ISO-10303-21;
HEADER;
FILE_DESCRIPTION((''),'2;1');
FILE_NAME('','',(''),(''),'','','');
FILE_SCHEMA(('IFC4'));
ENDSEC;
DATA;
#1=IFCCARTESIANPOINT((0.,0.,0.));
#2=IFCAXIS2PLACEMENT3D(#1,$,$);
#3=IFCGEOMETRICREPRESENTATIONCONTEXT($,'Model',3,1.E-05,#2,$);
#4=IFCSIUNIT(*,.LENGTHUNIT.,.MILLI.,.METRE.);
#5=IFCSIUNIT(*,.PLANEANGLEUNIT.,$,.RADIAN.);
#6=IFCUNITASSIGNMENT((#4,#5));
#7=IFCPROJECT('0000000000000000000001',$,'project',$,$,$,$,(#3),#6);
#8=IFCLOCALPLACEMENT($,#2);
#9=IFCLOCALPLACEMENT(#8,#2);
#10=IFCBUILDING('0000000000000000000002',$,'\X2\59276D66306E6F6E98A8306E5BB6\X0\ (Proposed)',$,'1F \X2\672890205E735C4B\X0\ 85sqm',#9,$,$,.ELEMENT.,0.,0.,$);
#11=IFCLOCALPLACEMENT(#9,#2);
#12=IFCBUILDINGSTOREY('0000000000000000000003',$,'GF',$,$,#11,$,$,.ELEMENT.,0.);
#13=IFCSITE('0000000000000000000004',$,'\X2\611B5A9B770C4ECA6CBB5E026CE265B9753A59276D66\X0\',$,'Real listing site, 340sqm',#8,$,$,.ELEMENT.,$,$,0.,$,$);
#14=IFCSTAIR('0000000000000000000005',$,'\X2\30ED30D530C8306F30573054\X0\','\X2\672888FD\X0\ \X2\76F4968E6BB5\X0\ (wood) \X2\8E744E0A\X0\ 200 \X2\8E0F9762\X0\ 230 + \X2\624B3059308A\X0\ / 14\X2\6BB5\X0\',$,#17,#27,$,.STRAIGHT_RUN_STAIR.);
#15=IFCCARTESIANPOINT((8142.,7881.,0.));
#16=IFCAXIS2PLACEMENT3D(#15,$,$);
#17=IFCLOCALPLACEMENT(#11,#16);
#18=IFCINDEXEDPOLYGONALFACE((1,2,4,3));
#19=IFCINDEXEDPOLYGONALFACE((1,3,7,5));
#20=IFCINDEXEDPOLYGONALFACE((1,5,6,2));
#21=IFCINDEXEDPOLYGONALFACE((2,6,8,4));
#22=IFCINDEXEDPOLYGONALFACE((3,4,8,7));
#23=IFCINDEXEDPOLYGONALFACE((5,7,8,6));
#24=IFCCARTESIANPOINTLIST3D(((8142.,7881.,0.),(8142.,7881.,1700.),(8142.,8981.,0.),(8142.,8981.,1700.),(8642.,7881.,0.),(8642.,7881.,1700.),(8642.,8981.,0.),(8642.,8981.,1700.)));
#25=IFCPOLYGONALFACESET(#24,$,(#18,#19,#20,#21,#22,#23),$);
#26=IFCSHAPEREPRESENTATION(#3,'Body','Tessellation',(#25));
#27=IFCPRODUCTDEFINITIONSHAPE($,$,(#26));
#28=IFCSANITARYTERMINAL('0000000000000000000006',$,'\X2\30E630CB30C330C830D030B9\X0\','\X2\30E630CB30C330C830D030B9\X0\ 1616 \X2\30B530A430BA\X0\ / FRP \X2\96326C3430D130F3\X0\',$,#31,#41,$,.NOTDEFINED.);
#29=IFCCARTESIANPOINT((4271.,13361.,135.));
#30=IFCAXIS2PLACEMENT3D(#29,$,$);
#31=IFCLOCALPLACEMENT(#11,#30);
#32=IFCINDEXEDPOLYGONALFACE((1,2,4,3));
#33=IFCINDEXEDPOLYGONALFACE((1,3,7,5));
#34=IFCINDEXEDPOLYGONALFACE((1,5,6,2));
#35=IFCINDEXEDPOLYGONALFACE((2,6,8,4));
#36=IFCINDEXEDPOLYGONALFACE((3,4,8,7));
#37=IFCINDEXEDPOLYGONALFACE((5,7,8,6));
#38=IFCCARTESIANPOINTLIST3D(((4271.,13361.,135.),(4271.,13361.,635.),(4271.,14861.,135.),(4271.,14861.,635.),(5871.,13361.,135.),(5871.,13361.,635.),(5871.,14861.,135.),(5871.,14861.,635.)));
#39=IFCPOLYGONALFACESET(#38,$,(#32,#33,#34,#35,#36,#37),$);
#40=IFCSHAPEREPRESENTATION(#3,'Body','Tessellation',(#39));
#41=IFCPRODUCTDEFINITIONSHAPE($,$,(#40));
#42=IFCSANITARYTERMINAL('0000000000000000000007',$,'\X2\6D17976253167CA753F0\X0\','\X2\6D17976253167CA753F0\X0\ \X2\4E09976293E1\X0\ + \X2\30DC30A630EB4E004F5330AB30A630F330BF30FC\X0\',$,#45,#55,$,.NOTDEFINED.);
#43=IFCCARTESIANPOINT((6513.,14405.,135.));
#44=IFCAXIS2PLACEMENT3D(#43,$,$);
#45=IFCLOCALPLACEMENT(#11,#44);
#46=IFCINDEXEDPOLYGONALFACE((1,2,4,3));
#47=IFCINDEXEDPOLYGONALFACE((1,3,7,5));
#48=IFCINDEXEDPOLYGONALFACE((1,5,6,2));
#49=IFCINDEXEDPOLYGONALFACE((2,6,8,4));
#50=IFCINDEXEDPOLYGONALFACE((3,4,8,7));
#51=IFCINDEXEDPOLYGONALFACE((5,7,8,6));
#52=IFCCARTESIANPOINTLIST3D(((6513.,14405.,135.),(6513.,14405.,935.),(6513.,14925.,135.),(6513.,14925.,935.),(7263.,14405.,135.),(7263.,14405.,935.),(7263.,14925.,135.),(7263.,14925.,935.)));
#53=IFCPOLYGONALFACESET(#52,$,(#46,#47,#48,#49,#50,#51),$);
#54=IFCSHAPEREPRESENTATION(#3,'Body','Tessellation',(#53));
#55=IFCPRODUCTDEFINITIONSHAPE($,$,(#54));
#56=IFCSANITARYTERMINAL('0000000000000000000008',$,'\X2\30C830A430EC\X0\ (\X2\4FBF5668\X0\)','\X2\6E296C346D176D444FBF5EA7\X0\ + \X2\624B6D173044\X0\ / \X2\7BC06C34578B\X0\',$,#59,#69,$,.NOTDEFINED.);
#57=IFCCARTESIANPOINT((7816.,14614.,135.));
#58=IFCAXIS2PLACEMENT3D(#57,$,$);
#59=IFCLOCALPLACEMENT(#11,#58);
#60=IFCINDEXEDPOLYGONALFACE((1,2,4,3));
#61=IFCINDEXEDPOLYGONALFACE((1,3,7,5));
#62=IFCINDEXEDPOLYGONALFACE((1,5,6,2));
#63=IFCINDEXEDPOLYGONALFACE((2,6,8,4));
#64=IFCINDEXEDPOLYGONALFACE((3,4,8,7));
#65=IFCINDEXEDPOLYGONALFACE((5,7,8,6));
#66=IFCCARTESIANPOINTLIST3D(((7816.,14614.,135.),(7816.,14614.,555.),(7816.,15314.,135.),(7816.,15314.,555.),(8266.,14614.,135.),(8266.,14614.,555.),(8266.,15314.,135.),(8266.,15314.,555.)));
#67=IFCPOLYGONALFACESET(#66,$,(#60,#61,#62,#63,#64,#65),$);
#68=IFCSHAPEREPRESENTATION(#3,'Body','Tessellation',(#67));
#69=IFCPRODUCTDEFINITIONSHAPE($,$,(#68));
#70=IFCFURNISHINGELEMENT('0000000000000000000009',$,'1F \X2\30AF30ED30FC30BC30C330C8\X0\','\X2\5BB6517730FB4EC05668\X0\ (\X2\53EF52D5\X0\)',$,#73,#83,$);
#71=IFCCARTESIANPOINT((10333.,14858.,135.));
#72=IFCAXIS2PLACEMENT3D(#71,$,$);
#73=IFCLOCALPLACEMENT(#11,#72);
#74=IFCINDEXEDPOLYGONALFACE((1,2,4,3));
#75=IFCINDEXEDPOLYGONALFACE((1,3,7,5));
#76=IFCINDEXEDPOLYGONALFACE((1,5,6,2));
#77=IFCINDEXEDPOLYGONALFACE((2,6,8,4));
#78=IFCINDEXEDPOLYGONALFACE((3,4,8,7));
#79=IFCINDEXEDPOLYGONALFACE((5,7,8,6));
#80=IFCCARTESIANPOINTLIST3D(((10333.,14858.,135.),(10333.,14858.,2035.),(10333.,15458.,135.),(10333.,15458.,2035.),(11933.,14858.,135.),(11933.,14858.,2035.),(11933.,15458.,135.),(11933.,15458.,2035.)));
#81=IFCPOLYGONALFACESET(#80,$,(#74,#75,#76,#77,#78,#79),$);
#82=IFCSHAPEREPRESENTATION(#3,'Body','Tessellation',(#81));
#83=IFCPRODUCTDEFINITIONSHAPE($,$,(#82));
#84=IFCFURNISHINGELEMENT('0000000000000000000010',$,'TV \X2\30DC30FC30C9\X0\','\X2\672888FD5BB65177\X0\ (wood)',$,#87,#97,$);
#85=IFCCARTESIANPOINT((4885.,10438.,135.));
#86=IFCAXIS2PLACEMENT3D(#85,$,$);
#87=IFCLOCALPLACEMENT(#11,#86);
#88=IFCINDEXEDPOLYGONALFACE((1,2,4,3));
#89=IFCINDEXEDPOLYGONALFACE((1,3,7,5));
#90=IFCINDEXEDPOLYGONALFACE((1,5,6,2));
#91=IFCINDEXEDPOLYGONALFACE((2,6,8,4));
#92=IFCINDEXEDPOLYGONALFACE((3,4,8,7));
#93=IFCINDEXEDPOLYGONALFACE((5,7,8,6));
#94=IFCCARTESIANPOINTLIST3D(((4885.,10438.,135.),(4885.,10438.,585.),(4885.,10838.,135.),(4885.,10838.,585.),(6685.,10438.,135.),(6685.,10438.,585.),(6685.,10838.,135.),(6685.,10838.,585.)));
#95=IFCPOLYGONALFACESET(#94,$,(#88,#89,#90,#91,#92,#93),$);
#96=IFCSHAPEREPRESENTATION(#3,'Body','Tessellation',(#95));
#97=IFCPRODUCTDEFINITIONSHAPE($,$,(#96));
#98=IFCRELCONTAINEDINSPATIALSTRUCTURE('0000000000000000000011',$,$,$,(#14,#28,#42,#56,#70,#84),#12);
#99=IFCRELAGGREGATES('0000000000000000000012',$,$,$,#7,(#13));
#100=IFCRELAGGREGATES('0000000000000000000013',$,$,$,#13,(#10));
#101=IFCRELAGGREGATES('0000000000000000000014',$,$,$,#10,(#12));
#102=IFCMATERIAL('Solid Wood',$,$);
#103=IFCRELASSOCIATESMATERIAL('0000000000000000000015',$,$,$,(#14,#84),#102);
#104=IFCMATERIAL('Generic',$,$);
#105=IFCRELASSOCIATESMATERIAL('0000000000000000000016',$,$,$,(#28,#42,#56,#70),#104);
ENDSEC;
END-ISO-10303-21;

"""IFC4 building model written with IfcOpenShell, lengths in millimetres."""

from ifc_helpers import new_model, si_unit, frame, frame_2d, origin, place, context, project, spatial, rectangle, extrude, material, element, save


model = new_model("IFC4")

# Units and contexts
model_context = context("Model", 3, precision=1e-05, world=origin())
ifc_project = project(units=[si_unit("LENGTHUNIT", "METRE", prefix="MILLI"), si_unit("PLANEANGLEUNIT", "RADIAN")], contexts=[model_context])

# Site, building, storey
site_placement = place(None, origin())
site = spatial("IfcSite", under=ifc_project, at=site_placement, Name="愛媛県今治市波方町大浦", ObjectType="Real listing site, 340sqm", CompositionType="ELEMENT", RefElevation=0.0)
building_placement = place(site_placement, origin())
building = spatial("IfcBuilding", under=site, at=building_placement, Name="大浦の潮風の家 (Proposed)", ObjectType="1F 木造平屋 85sqm", CompositionType="ELEMENT", ElevationOfRefHeight=0.0, ElevationOfTerrain=0.0)
storey_placement = place(building_placement, origin())
storey = spatial("IfcBuildingStorey", under=building, at=storey_placement, Name="GF", CompositionType="ELEMENT", Elevation=0.0)

# Shared definitions
ifc_material_1 = material(Name="Solid Wood")

# Stair
stair_placement = place(storey_placement, frame((8142.0, 7881.0, 0.0)))
element("IfcStair", 1, at=stair_placement, inside=storey, material=ifc_material_1, Name="ロフトはしご", Description="木製 直階段 (wood) 蹴上 200 踏面 230 + 手すり / 14段", PredefinedType="STRAIGHT_RUN_STAIR", context=model_context, shape_type="SweptSolid", body=[
    extrude(rectangle(XDim=500.0, YDim=1100.0, at=frame_2d((250.0, 550.0))), frame((8142.0, 7881.0, 0.0)), (0.0, 0.0, 1.0), 1700.0),
])

# Sanitary terminals
ifc_material_2 = material(Name="Generic")
sanitary_terminal_1_placement = place(storey_placement, frame((4271.0, 13361.0, 135.0)))
element("IfcSanitaryTerminal", 2, at=sanitary_terminal_1_placement, inside=storey, material=ifc_material_2, Name="ユニットバス", Description="ユニットバス 1616 サイズ / FRP 防水パン", PredefinedType="NOTDEFINED", context=model_context, shape_type="SweptSolid", body=[
    extrude(rectangle(XDim=1600.0, YDim=1500.0, at=frame_2d((800.0, 750.0))), frame((4271.0, 13361.0, 135.0)), (0.0, 0.0, 1.0), 500.0),
])
sanitary_terminal_2_placement = place(storey_placement, frame((6513.0, 14405.0, 135.0)))
element("IfcSanitaryTerminal", 3, at=sanitary_terminal_2_placement, inside=storey, material=ifc_material_2, Name="洗面化粧台", Description="洗面化粧台 三面鏡 + ボウル一体カウンター", PredefinedType="NOTDEFINED", context=model_context, shape_type="SweptSolid", body=[
    extrude(rectangle(XDim=750.0, YDim=520.0, at=frame_2d((375.0, 260.0))), frame((6513.0, 14405.0, 135.0)), (0.0, 0.0, 1.0), 800.0),
])
sanitary_terminal_3_placement = place(storey_placement, frame((7816.0, 14614.0, 135.0)))
element("IfcSanitaryTerminal", 4, at=sanitary_terminal_3_placement, inside=storey, material=ifc_material_2, Name="トイレ (便器)", Description="温水洗浄便座 + 手洗い / 節水型", PredefinedType="NOTDEFINED", context=model_context, shape_type="SweptSolid", body=[
    extrude(rectangle(XDim=450.0, YDim=700.0, at=frame_2d((225.0, 350.0))), frame((7816.0, 14614.0, 135.0)), (0.0, 0.0, 1.0), 420.0),
])

# Furnishing elements
furnishing_1_placement = place(storey_placement, frame((10333.0, 14858.0, 135.0)))
element("IfcFurnishingElement", 5, at=furnishing_1_placement, inside=storey, material=ifc_material_2, Name="1F クローゼット", Description="家具・什器 (可動)", context=model_context, shape_type="SweptSolid", body=[
    extrude(rectangle(XDim=1600.0, YDim=600.0, at=frame_2d((800.0, 300.0))), frame((10333.0, 14858.0, 135.0)), (0.0, 0.0, 1.0), 1900.0),
])
furnishing_2_placement = place(storey_placement, frame((4885.0, 10438.0, 135.0)))
element("IfcFurnishingElement", 6, at=furnishing_2_placement, inside=storey, material=ifc_material_1, Name="TV ボード", Description="木製家具 (wood)", context=model_context, shape_type="SweptSolid", body=[
    extrude(rectangle(XDim=1800.0, YDim=400.0, at=frame_2d((900.0, 200.0))), frame((4885.0, 10438.0, 135.0)), (0.0, 0.0, 1.0), 450.0),
])

save(model, "model.ifc")
